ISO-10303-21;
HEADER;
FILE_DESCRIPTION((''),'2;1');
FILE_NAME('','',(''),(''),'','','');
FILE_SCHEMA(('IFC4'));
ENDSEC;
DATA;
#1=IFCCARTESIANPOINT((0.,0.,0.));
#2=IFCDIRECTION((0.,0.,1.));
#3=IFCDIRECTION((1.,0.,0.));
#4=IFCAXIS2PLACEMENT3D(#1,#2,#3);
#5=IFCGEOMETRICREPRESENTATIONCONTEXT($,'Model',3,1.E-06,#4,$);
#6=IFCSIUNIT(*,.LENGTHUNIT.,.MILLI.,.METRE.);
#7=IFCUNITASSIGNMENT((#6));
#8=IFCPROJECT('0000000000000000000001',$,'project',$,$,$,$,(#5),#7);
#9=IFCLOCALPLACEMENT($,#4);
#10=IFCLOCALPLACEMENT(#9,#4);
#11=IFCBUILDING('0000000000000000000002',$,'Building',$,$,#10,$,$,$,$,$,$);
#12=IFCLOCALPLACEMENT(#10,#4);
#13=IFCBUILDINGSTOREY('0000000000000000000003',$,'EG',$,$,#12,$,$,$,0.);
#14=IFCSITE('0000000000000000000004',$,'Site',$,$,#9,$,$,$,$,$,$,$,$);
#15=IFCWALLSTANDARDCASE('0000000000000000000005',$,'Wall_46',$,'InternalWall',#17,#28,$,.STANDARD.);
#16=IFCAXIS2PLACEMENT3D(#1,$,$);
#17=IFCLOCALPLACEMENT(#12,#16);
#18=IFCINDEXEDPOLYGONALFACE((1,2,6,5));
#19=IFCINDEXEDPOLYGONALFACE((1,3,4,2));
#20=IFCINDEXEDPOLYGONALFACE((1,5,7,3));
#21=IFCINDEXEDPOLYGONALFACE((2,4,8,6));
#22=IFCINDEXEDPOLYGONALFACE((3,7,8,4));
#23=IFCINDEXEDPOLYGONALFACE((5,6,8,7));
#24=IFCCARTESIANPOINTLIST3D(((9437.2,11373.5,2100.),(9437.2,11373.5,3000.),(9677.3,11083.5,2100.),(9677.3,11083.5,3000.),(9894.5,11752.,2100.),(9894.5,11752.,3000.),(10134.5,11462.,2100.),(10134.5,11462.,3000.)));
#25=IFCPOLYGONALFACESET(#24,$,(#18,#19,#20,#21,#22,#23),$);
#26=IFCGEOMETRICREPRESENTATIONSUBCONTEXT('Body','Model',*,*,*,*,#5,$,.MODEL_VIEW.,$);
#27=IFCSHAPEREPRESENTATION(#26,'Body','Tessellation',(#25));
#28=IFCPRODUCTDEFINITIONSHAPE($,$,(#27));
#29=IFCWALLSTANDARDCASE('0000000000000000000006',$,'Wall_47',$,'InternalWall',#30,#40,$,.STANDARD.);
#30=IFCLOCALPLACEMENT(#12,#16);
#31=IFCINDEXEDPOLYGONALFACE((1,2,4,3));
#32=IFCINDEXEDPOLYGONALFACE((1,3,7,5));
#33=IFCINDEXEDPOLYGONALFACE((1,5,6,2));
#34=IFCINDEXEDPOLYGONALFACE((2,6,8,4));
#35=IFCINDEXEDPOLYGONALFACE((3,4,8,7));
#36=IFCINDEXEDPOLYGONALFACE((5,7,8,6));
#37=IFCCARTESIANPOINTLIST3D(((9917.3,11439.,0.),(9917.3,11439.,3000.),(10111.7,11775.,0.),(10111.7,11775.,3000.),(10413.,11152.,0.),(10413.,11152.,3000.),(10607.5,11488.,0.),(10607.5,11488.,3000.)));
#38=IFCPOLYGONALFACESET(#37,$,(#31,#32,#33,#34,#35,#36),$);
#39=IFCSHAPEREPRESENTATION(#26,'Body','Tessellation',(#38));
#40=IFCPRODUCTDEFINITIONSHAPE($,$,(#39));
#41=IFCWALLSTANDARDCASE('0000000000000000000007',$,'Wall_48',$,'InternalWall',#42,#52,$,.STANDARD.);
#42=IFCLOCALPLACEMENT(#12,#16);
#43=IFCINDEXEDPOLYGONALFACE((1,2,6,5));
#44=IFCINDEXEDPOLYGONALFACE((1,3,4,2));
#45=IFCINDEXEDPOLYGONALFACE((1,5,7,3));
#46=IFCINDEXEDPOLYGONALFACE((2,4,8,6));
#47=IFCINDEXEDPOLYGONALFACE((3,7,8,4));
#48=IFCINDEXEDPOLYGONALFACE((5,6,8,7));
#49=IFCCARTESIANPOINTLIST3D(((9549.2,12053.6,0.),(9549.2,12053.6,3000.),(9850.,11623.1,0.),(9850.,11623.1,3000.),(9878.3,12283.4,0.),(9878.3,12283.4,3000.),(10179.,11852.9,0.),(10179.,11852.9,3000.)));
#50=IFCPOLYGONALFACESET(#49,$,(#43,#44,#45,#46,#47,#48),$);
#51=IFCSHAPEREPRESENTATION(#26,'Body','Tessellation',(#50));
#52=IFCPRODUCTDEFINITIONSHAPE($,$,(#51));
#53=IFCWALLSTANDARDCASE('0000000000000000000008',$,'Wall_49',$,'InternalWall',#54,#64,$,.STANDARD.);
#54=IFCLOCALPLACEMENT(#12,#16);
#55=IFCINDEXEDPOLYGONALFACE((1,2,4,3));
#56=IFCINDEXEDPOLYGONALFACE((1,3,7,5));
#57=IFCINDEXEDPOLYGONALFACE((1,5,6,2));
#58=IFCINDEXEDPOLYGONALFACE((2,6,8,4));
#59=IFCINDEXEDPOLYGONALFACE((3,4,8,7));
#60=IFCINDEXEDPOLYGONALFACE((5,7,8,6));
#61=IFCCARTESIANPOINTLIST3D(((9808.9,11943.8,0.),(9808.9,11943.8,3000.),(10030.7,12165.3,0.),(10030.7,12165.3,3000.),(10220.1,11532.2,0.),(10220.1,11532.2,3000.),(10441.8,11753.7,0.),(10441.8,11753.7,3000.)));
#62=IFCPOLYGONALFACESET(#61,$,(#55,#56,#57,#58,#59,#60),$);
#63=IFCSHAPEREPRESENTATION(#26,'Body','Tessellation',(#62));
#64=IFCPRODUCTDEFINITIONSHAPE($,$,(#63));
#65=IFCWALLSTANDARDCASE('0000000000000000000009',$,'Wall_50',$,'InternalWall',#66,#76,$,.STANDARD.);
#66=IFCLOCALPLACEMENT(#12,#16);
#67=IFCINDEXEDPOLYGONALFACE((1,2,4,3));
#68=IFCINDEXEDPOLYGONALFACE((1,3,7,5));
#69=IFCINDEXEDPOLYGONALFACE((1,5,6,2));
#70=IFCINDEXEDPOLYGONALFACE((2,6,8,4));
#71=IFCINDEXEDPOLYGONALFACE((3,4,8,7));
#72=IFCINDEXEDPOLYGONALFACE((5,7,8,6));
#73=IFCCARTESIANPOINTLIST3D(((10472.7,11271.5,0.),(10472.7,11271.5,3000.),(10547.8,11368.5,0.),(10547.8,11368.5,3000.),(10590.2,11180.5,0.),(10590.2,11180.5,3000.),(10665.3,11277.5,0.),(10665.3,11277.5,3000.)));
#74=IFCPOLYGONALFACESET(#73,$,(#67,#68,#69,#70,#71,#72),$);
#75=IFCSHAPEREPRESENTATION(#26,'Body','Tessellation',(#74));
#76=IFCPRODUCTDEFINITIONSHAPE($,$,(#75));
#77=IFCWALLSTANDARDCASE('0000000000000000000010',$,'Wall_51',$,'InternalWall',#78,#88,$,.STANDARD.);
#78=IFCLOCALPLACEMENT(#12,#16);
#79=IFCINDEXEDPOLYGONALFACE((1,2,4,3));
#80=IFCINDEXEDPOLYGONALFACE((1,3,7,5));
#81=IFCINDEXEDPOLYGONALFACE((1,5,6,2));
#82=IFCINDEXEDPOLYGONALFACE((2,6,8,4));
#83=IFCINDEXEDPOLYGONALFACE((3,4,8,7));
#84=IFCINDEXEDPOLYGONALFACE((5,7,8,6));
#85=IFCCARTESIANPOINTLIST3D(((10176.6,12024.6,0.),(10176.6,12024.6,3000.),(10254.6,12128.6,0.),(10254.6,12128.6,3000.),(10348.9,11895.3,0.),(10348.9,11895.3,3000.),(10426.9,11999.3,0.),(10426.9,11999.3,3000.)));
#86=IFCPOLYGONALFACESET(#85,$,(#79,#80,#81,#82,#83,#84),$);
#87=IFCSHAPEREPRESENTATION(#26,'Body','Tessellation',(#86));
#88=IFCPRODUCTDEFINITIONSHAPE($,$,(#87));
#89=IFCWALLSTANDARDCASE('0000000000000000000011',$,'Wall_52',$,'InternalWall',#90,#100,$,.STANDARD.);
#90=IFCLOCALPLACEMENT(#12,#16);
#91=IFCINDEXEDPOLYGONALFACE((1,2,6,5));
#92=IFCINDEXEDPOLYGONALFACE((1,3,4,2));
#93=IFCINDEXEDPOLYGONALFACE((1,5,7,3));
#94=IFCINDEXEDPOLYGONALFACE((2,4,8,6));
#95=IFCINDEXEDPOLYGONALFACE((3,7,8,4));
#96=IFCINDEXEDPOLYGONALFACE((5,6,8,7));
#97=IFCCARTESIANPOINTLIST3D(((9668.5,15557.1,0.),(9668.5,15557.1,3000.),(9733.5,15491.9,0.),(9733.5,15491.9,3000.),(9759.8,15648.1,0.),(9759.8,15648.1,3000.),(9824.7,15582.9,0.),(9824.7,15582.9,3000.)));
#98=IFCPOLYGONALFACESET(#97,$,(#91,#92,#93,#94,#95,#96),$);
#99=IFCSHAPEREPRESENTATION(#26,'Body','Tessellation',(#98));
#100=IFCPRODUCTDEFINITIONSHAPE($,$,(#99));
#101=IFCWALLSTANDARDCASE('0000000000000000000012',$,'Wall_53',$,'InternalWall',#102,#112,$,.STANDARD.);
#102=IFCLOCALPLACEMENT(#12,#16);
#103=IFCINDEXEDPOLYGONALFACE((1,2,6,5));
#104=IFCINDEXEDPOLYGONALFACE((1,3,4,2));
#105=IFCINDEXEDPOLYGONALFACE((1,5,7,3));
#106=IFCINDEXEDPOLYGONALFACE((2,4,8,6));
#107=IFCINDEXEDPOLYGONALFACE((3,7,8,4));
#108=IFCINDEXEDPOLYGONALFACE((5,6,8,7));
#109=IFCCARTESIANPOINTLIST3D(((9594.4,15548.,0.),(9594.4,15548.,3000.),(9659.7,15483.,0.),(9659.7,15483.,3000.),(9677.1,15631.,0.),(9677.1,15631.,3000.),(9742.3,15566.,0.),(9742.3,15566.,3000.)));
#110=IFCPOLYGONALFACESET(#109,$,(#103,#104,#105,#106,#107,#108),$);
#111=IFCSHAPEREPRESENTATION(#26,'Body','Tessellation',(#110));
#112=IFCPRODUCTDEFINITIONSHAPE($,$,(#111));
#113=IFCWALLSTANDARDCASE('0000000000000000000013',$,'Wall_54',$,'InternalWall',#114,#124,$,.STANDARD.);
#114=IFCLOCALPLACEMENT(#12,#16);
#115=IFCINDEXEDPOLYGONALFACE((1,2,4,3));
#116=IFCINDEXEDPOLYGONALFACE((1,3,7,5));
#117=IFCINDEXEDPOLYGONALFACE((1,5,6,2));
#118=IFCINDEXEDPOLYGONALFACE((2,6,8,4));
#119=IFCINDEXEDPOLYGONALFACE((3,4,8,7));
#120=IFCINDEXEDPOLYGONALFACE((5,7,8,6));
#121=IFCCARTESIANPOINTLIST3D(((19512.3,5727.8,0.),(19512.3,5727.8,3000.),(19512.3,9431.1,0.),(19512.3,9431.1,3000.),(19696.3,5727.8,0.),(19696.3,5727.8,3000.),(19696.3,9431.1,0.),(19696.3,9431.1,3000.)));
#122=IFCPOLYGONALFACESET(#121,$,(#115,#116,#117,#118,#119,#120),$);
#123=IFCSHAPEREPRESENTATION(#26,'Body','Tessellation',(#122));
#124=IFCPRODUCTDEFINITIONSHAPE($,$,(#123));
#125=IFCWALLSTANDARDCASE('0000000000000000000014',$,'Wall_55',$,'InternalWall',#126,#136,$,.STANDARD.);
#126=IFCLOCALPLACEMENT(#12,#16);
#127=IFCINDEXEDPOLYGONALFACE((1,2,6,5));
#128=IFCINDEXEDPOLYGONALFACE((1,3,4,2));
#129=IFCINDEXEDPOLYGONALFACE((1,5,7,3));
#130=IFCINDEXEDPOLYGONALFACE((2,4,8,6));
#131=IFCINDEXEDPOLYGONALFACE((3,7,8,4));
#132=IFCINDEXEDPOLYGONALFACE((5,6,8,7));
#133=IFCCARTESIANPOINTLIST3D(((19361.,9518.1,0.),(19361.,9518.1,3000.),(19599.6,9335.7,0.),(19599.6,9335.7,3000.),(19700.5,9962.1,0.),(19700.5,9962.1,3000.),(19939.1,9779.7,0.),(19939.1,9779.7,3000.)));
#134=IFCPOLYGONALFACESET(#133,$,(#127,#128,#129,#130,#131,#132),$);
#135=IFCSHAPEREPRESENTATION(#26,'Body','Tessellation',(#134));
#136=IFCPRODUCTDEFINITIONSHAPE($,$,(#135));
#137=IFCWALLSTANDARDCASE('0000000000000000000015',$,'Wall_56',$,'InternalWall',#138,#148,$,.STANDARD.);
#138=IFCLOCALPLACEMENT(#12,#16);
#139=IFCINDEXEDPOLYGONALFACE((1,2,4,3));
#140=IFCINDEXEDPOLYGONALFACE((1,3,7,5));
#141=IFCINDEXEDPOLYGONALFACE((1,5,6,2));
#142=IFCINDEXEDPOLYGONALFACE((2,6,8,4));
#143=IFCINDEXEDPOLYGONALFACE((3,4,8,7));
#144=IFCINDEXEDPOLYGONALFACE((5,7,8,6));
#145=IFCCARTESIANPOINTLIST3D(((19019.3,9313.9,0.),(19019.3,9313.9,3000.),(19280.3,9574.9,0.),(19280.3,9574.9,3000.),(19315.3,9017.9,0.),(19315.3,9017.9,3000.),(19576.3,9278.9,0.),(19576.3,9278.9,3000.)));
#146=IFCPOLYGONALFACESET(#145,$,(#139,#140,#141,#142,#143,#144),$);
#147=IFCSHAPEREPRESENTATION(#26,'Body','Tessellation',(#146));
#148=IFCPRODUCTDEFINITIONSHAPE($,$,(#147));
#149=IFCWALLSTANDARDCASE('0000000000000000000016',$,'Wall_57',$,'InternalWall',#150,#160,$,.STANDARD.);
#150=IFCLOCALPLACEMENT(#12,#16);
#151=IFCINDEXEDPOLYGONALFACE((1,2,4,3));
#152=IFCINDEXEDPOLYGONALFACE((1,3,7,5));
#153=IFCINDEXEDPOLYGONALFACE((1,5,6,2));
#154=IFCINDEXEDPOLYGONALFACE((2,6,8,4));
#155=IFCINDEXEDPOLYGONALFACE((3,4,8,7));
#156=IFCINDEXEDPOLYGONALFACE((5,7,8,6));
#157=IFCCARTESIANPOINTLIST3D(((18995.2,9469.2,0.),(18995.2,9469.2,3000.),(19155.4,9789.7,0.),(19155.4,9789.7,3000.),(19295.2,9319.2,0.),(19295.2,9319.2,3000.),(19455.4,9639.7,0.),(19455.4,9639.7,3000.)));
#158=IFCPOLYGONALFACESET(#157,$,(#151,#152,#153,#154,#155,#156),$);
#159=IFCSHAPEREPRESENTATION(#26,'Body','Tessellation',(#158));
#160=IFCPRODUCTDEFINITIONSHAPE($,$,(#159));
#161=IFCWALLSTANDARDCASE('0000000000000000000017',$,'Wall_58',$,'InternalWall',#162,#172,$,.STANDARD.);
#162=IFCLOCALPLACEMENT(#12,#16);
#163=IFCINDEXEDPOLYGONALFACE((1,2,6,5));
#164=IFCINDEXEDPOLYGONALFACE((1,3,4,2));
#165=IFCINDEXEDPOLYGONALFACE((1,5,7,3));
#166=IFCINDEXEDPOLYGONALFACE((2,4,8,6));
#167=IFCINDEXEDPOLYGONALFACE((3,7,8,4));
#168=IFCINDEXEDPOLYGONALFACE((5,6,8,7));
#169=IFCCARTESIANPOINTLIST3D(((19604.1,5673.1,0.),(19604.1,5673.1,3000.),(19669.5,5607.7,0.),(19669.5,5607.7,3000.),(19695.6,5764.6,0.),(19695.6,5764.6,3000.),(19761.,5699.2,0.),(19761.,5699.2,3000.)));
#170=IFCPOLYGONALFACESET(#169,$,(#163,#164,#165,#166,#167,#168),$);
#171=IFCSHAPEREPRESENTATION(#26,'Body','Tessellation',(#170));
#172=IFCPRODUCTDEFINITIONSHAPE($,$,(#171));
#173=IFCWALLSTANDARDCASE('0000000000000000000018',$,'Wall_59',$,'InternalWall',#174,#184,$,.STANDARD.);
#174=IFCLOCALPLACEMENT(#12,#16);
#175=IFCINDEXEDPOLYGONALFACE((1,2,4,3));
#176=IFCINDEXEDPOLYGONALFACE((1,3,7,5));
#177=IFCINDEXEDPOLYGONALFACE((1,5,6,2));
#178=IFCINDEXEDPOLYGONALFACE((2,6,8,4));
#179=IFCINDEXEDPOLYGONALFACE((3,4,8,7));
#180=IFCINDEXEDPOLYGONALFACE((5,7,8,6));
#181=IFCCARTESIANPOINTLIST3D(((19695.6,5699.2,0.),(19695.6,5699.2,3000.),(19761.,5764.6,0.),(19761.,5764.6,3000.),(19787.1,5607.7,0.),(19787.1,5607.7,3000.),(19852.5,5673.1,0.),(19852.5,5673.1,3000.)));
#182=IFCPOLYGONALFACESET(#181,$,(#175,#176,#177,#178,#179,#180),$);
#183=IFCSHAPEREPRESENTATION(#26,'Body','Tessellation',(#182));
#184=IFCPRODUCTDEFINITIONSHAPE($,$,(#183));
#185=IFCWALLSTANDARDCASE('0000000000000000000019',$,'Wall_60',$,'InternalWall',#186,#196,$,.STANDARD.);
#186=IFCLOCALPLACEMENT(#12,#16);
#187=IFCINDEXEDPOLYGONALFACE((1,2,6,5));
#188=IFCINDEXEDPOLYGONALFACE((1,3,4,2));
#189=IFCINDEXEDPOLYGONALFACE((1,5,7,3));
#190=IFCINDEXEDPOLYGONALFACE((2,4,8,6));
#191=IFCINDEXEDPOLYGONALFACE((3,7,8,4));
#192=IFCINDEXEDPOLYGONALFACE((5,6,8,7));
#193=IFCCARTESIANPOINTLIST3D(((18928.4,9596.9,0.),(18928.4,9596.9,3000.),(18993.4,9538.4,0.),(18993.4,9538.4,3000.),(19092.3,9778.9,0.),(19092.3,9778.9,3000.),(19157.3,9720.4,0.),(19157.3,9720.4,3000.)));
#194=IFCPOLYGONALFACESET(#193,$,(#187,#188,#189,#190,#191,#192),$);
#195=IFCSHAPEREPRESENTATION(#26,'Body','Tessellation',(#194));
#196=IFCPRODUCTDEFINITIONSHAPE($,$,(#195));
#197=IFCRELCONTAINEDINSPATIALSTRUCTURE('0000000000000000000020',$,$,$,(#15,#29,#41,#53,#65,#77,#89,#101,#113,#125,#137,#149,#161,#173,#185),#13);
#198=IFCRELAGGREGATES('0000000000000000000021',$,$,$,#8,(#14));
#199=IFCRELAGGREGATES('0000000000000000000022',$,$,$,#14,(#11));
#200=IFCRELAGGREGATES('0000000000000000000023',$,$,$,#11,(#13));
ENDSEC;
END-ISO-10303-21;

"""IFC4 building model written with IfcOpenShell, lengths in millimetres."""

from ifc_helpers import new_model, si_unit, frame, origin_with_axes, place, context, subcontext, project, spatial, rectangle, extrude, element, save


model = new_model("IFC4")

# Units and contexts
model_context = context("Model", 3, precision=1e-06, world=origin_with_axes())
body_context = subcontext(model_context, "Body", "Model", "MODEL_VIEW")
ifc_project = project(units=[si_unit("LENGTHUNIT", "METRE", prefix="MILLI")], contexts=[model_context])

# Site, building, storey
site_placement = place(None, origin_with_axes())
site = spatial("IfcSite", under=ifc_project, at=site_placement, Name="Site")
building_placement = place(site_placement, origin_with_axes())
building = spatial("IfcBuilding", under=site, at=building_placement, Name="Building")
storey_placement = place(building_placement, origin_with_axes())
storey = spatial("IfcBuildingStorey", under=building, at=storey_placement, Name="EG", Elevation=0.0)

# Wall, opening
wall_1_placement = place(storey_placement, origin_with_axes())
wall_1 = element("IfcWallStandardCase", 1, at=wall_1_placement, inside=storey, Name="Wall_46", ObjectType="InternalWall", PredefinedType="STANDARD", context=body_context, shape_type="SweptSolid", body=[
    extrude(rectangle(XDim=593.6, YDim=376.5), frame((9785.9, 11417.7, 0.0), z_axis=(0.0, 0.0, 1.0), x_axis=(-0.770323, -0.637654, 0.0)), (0.0, 0.0, 1.0), 3000.0),
])
opening_1_placement = place(wall_1_placement, origin_with_axes())
element("IfcOpeningElement", 2, at=opening_1_placement, inside=storey, cuts=wall_1, context=body_context, shape_type="SweptSolid", body=[
    extrude(rectangle(XDim=593.6, YDim=376.5), frame((9785.9, 11417.7, 0.0), z_axis=(0.0, 0.0, 1.0), x_axis=(-0.770323, -0.637654, 0.0)), (0.0, 0.0, 1.0), 2100.0),
])

# Walls
wall_2_placement = place(storey_placement, origin_with_axes())
element("IfcWallStandardCase", 3, at=wall_2_placement, inside=storey, Name="Wall_47", ObjectType="InternalWall", PredefinedType="STANDARD", context=body_context, shape_type="SweptSolid", body=[
    extrude(rectangle(XDim=572.8, YDim=388.2), frame((10262.4, 11463.5, 0.0), z_axis=(0.0, 0.0, 1.0), x_axis=(0.865436, -0.501019, 0.0)), (0.0, 0.0, 1.0), 3000.0),
])
wall_3_placement = place(storey_placement, origin_with_axes())
element("IfcWallStandardCase", 4, at=wall_3_placement, inside=storey, Name="Wall_48", ObjectType="InternalWall", PredefinedType="STANDARD", context=body_context, shape_type="SweptSolid", body=[
    extrude(rectangle(XDim=525.1, YDim=401.4), frame((9864.1, 11953.2, 0.0), z_axis=(0.0, 0.0, 1.0), x_axis=(0.572695, -0.819768, 0.0)), (0.0, 0.0, 1.0), 3000.0),
])
wall_4_placement = place(storey_placement, origin_with_axes())
element("IfcWallStandardCase", 5, at=wall_4_placement, inside=storey, Name="Wall_49", ObjectType="InternalWall", PredefinedType="STANDARD", context=body_context, shape_type="SweptSolid", body=[
    extrude(rectangle(XDim=313.4, YDim=581.8), frame((10125.4, 11848.7, 0.0), z_axis=(0.0, 0.0, 1.0), x_axis=(0.707505, 0.706708, 0.0)), (0.0, 0.0, 1.0), 3000.0),
])
wall_5_placement = place(storey_placement, origin_with_axes())
element("IfcWallStandardCase", 6, at=wall_5_placement, inside=storey, Name="Wall_50", ObjectType="InternalWall", PredefinedType="STANDARD", context=body_context, shape_type="SweptSolid", body=[
    extrude(rectangle(XDim=148.6, YDim=122.6), frame((10569.0, 11274.5, 0.0), z_axis=(0.0, 0.0, 1.0), x_axis=(0.790619, -0.612309, 0.0)), (0.0, 0.0, 1.0), 3000.0),
])
wall_6_placement = place(storey_placement, origin_with_axes())
element("IfcWallStandardCase", 7, at=wall_6_placement, inside=storey, Name="Wall_51", ObjectType="InternalWall", PredefinedType="STANDARD", context=body_context, shape_type="SweptSolid", body=[
    extrude(rectangle(XDim=130.0, YDim=215.5), frame((10301.8, 12012.0, 0.0), z_axis=(0.0, 0.0, 1.0), x_axis=(-0.6, -0.8, 0.0)), (0.0, 0.0, 1.0), 3000.0),
])
wall_7_placement = place(storey_placement, origin_with_axes())
element("IfcWallStandardCase", 8, at=wall_7_placement, inside=storey, Name="Wall_52", ObjectType="InternalWall", PredefinedType="STANDARD", context=body_context, shape_type="SweptSolid", body=[
    extrude(rectangle(XDim=128.9, YDim=92.0), frame((9746.6, 15570.0, 0.0), z_axis=(0.0, 0.0, 1.0), x_axis=(0.708076, 0.706136, 0.0)), (0.0, 0.0, 1.0), 3000.0),
])
wall_8_placement = place(storey_placement, origin_with_axes())
element("IfcWallStandardCase", 9, at=wall_8_placement, inside=storey, Name="Wall_53", ObjectType="InternalWall", PredefinedType="STANDARD", context=body_context, shape_type="SweptSolid", body=[
    extrude(rectangle(XDim=92.1, YDim=117.1), frame((9668.4, 15557.0, 0.0), z_axis=(0.0, 0.0, 1.0), x_axis=(-0.708463, 0.705748, 0.0)), (0.0, 0.0, 1.0), 3000.0),
])
wall_9_placement = place(storey_placement, origin_with_axes())
element("IfcWallStandardCase", 10, at=wall_9_placement, inside=storey, Name="Wall_54", ObjectType="InternalWall", PredefinedType="STANDARD", context=body_context, shape_type="SweptSolid", body=[
    extrude(rectangle(XDim=3703.3, YDim=184.0), frame((19604.3, 7579.4, 0.0), z_axis=(0.0, 0.0, 1.0), x_axis=(0.0, 1.0, 0.0)), (0.0, 0.0, 1.0), 3000.0),
])
wall_10_placement = place(storey_placement, origin_with_axes())
element("IfcWallStandardCase", 11, at=wall_10_placement, inside=storey, Name="Wall_55", ObjectType="InternalWall", PredefinedType="STANDARD", context=body_context, shape_type="SweptSolid", body=[
    extrude(rectangle(XDim=558.9, YDim=300.4), frame((19650.1, 9648.9, 0.0), z_axis=(0.0, 0.0, 1.0), x_axis=(0.607417, 0.794383, 0.0)), (0.0, 0.0, 1.0), 3000.0),
])
wall_11_placement = place(storey_placement, origin_with_axes())
element("IfcWallStandardCase", 12, at=wall_11_placement, inside=storey, Name="Wall_56", ObjectType="InternalWall", PredefinedType="STANDARD", context=body_context, shape_type="SweptSolid", body=[
    extrude(rectangle(XDim=369.1, YDim=418.6), frame((19297.8, 9296.4, 0.0), z_axis=(0.0, 0.0, 1.0), x_axis=(-0.707107, -0.707107, 0.0)), (0.0, 0.0, 1.0), 3000.0),
])
wall_12_placement = place(storey_placement, origin_with_axes())
element("IfcWallStandardCase", 13, at=wall_12_placement, inside=storey, Name="Wall_57", ObjectType="InternalWall", PredefinedType="STANDARD", context=body_context, shape_type="SweptSolid", body=[
    extrude(rectangle(XDim=335.4, YDim=358.3), frame((19225.3, 9554.4, 0.0), z_axis=(0.0, 0.0, 1.0), x_axis=(-0.894427, 0.447214, 0.0)), (0.0, 0.0, 1.0), 3000.0),
])
wall_13_placement = place(storey_placement, origin_with_axes())
element("IfcWallStandardCase", 14, at=wall_13_placement, inside=storey, Name="Wall_58", ObjectType="InternalWall", PredefinedType="STANDARD", context=body_context, shape_type="SweptSolid", body=[
    extrude(rectangle(XDim=129.4, YDim=92.5), frame((19682.6, 5686.2, 0.0), z_axis=(0.0, 0.0, 1.0), x_axis=(-0.707107, -0.707107, 0.0)), (0.0, 0.0, 1.0), 3000.0),
])
wall_14_placement = place(storey_placement, origin_with_axes())
element("IfcWallStandardCase", 15, at=wall_14_placement, inside=storey, Name="Wall_59", ObjectType="InternalWall", PredefinedType="STANDARD", context=body_context, shape_type="SweptSolid", body=[
    extrude(rectangle(XDim=129.4, YDim=92.5), frame((19774.1, 5686.2, 0.0), z_axis=(0.0, 0.0, 1.0), x_axis=(0.707107, -0.707107, 0.0)), (0.0, 0.0, 1.0), 3000.0),
])
wall_15_placement = place(storey_placement, origin_with_axes())
element("IfcWallStandardCase", 16, at=wall_15_placement, inside=storey, Name="Wall_60", ObjectType="InternalWall", PredefinedType="STANDARD", context=body_context, shape_type="SweptSolid", body=[
    extrude(rectangle(XDim=87.4, YDim=244.9), frame((19042.8, 9658.7, 0.0), z_axis=(0.0, 0.0, 1.0), x_axis=(-0.743294, 0.668965, 0.0)), (0.0, 0.0, 1.0), 3000.0),
])

save(model, "model.ifc")
